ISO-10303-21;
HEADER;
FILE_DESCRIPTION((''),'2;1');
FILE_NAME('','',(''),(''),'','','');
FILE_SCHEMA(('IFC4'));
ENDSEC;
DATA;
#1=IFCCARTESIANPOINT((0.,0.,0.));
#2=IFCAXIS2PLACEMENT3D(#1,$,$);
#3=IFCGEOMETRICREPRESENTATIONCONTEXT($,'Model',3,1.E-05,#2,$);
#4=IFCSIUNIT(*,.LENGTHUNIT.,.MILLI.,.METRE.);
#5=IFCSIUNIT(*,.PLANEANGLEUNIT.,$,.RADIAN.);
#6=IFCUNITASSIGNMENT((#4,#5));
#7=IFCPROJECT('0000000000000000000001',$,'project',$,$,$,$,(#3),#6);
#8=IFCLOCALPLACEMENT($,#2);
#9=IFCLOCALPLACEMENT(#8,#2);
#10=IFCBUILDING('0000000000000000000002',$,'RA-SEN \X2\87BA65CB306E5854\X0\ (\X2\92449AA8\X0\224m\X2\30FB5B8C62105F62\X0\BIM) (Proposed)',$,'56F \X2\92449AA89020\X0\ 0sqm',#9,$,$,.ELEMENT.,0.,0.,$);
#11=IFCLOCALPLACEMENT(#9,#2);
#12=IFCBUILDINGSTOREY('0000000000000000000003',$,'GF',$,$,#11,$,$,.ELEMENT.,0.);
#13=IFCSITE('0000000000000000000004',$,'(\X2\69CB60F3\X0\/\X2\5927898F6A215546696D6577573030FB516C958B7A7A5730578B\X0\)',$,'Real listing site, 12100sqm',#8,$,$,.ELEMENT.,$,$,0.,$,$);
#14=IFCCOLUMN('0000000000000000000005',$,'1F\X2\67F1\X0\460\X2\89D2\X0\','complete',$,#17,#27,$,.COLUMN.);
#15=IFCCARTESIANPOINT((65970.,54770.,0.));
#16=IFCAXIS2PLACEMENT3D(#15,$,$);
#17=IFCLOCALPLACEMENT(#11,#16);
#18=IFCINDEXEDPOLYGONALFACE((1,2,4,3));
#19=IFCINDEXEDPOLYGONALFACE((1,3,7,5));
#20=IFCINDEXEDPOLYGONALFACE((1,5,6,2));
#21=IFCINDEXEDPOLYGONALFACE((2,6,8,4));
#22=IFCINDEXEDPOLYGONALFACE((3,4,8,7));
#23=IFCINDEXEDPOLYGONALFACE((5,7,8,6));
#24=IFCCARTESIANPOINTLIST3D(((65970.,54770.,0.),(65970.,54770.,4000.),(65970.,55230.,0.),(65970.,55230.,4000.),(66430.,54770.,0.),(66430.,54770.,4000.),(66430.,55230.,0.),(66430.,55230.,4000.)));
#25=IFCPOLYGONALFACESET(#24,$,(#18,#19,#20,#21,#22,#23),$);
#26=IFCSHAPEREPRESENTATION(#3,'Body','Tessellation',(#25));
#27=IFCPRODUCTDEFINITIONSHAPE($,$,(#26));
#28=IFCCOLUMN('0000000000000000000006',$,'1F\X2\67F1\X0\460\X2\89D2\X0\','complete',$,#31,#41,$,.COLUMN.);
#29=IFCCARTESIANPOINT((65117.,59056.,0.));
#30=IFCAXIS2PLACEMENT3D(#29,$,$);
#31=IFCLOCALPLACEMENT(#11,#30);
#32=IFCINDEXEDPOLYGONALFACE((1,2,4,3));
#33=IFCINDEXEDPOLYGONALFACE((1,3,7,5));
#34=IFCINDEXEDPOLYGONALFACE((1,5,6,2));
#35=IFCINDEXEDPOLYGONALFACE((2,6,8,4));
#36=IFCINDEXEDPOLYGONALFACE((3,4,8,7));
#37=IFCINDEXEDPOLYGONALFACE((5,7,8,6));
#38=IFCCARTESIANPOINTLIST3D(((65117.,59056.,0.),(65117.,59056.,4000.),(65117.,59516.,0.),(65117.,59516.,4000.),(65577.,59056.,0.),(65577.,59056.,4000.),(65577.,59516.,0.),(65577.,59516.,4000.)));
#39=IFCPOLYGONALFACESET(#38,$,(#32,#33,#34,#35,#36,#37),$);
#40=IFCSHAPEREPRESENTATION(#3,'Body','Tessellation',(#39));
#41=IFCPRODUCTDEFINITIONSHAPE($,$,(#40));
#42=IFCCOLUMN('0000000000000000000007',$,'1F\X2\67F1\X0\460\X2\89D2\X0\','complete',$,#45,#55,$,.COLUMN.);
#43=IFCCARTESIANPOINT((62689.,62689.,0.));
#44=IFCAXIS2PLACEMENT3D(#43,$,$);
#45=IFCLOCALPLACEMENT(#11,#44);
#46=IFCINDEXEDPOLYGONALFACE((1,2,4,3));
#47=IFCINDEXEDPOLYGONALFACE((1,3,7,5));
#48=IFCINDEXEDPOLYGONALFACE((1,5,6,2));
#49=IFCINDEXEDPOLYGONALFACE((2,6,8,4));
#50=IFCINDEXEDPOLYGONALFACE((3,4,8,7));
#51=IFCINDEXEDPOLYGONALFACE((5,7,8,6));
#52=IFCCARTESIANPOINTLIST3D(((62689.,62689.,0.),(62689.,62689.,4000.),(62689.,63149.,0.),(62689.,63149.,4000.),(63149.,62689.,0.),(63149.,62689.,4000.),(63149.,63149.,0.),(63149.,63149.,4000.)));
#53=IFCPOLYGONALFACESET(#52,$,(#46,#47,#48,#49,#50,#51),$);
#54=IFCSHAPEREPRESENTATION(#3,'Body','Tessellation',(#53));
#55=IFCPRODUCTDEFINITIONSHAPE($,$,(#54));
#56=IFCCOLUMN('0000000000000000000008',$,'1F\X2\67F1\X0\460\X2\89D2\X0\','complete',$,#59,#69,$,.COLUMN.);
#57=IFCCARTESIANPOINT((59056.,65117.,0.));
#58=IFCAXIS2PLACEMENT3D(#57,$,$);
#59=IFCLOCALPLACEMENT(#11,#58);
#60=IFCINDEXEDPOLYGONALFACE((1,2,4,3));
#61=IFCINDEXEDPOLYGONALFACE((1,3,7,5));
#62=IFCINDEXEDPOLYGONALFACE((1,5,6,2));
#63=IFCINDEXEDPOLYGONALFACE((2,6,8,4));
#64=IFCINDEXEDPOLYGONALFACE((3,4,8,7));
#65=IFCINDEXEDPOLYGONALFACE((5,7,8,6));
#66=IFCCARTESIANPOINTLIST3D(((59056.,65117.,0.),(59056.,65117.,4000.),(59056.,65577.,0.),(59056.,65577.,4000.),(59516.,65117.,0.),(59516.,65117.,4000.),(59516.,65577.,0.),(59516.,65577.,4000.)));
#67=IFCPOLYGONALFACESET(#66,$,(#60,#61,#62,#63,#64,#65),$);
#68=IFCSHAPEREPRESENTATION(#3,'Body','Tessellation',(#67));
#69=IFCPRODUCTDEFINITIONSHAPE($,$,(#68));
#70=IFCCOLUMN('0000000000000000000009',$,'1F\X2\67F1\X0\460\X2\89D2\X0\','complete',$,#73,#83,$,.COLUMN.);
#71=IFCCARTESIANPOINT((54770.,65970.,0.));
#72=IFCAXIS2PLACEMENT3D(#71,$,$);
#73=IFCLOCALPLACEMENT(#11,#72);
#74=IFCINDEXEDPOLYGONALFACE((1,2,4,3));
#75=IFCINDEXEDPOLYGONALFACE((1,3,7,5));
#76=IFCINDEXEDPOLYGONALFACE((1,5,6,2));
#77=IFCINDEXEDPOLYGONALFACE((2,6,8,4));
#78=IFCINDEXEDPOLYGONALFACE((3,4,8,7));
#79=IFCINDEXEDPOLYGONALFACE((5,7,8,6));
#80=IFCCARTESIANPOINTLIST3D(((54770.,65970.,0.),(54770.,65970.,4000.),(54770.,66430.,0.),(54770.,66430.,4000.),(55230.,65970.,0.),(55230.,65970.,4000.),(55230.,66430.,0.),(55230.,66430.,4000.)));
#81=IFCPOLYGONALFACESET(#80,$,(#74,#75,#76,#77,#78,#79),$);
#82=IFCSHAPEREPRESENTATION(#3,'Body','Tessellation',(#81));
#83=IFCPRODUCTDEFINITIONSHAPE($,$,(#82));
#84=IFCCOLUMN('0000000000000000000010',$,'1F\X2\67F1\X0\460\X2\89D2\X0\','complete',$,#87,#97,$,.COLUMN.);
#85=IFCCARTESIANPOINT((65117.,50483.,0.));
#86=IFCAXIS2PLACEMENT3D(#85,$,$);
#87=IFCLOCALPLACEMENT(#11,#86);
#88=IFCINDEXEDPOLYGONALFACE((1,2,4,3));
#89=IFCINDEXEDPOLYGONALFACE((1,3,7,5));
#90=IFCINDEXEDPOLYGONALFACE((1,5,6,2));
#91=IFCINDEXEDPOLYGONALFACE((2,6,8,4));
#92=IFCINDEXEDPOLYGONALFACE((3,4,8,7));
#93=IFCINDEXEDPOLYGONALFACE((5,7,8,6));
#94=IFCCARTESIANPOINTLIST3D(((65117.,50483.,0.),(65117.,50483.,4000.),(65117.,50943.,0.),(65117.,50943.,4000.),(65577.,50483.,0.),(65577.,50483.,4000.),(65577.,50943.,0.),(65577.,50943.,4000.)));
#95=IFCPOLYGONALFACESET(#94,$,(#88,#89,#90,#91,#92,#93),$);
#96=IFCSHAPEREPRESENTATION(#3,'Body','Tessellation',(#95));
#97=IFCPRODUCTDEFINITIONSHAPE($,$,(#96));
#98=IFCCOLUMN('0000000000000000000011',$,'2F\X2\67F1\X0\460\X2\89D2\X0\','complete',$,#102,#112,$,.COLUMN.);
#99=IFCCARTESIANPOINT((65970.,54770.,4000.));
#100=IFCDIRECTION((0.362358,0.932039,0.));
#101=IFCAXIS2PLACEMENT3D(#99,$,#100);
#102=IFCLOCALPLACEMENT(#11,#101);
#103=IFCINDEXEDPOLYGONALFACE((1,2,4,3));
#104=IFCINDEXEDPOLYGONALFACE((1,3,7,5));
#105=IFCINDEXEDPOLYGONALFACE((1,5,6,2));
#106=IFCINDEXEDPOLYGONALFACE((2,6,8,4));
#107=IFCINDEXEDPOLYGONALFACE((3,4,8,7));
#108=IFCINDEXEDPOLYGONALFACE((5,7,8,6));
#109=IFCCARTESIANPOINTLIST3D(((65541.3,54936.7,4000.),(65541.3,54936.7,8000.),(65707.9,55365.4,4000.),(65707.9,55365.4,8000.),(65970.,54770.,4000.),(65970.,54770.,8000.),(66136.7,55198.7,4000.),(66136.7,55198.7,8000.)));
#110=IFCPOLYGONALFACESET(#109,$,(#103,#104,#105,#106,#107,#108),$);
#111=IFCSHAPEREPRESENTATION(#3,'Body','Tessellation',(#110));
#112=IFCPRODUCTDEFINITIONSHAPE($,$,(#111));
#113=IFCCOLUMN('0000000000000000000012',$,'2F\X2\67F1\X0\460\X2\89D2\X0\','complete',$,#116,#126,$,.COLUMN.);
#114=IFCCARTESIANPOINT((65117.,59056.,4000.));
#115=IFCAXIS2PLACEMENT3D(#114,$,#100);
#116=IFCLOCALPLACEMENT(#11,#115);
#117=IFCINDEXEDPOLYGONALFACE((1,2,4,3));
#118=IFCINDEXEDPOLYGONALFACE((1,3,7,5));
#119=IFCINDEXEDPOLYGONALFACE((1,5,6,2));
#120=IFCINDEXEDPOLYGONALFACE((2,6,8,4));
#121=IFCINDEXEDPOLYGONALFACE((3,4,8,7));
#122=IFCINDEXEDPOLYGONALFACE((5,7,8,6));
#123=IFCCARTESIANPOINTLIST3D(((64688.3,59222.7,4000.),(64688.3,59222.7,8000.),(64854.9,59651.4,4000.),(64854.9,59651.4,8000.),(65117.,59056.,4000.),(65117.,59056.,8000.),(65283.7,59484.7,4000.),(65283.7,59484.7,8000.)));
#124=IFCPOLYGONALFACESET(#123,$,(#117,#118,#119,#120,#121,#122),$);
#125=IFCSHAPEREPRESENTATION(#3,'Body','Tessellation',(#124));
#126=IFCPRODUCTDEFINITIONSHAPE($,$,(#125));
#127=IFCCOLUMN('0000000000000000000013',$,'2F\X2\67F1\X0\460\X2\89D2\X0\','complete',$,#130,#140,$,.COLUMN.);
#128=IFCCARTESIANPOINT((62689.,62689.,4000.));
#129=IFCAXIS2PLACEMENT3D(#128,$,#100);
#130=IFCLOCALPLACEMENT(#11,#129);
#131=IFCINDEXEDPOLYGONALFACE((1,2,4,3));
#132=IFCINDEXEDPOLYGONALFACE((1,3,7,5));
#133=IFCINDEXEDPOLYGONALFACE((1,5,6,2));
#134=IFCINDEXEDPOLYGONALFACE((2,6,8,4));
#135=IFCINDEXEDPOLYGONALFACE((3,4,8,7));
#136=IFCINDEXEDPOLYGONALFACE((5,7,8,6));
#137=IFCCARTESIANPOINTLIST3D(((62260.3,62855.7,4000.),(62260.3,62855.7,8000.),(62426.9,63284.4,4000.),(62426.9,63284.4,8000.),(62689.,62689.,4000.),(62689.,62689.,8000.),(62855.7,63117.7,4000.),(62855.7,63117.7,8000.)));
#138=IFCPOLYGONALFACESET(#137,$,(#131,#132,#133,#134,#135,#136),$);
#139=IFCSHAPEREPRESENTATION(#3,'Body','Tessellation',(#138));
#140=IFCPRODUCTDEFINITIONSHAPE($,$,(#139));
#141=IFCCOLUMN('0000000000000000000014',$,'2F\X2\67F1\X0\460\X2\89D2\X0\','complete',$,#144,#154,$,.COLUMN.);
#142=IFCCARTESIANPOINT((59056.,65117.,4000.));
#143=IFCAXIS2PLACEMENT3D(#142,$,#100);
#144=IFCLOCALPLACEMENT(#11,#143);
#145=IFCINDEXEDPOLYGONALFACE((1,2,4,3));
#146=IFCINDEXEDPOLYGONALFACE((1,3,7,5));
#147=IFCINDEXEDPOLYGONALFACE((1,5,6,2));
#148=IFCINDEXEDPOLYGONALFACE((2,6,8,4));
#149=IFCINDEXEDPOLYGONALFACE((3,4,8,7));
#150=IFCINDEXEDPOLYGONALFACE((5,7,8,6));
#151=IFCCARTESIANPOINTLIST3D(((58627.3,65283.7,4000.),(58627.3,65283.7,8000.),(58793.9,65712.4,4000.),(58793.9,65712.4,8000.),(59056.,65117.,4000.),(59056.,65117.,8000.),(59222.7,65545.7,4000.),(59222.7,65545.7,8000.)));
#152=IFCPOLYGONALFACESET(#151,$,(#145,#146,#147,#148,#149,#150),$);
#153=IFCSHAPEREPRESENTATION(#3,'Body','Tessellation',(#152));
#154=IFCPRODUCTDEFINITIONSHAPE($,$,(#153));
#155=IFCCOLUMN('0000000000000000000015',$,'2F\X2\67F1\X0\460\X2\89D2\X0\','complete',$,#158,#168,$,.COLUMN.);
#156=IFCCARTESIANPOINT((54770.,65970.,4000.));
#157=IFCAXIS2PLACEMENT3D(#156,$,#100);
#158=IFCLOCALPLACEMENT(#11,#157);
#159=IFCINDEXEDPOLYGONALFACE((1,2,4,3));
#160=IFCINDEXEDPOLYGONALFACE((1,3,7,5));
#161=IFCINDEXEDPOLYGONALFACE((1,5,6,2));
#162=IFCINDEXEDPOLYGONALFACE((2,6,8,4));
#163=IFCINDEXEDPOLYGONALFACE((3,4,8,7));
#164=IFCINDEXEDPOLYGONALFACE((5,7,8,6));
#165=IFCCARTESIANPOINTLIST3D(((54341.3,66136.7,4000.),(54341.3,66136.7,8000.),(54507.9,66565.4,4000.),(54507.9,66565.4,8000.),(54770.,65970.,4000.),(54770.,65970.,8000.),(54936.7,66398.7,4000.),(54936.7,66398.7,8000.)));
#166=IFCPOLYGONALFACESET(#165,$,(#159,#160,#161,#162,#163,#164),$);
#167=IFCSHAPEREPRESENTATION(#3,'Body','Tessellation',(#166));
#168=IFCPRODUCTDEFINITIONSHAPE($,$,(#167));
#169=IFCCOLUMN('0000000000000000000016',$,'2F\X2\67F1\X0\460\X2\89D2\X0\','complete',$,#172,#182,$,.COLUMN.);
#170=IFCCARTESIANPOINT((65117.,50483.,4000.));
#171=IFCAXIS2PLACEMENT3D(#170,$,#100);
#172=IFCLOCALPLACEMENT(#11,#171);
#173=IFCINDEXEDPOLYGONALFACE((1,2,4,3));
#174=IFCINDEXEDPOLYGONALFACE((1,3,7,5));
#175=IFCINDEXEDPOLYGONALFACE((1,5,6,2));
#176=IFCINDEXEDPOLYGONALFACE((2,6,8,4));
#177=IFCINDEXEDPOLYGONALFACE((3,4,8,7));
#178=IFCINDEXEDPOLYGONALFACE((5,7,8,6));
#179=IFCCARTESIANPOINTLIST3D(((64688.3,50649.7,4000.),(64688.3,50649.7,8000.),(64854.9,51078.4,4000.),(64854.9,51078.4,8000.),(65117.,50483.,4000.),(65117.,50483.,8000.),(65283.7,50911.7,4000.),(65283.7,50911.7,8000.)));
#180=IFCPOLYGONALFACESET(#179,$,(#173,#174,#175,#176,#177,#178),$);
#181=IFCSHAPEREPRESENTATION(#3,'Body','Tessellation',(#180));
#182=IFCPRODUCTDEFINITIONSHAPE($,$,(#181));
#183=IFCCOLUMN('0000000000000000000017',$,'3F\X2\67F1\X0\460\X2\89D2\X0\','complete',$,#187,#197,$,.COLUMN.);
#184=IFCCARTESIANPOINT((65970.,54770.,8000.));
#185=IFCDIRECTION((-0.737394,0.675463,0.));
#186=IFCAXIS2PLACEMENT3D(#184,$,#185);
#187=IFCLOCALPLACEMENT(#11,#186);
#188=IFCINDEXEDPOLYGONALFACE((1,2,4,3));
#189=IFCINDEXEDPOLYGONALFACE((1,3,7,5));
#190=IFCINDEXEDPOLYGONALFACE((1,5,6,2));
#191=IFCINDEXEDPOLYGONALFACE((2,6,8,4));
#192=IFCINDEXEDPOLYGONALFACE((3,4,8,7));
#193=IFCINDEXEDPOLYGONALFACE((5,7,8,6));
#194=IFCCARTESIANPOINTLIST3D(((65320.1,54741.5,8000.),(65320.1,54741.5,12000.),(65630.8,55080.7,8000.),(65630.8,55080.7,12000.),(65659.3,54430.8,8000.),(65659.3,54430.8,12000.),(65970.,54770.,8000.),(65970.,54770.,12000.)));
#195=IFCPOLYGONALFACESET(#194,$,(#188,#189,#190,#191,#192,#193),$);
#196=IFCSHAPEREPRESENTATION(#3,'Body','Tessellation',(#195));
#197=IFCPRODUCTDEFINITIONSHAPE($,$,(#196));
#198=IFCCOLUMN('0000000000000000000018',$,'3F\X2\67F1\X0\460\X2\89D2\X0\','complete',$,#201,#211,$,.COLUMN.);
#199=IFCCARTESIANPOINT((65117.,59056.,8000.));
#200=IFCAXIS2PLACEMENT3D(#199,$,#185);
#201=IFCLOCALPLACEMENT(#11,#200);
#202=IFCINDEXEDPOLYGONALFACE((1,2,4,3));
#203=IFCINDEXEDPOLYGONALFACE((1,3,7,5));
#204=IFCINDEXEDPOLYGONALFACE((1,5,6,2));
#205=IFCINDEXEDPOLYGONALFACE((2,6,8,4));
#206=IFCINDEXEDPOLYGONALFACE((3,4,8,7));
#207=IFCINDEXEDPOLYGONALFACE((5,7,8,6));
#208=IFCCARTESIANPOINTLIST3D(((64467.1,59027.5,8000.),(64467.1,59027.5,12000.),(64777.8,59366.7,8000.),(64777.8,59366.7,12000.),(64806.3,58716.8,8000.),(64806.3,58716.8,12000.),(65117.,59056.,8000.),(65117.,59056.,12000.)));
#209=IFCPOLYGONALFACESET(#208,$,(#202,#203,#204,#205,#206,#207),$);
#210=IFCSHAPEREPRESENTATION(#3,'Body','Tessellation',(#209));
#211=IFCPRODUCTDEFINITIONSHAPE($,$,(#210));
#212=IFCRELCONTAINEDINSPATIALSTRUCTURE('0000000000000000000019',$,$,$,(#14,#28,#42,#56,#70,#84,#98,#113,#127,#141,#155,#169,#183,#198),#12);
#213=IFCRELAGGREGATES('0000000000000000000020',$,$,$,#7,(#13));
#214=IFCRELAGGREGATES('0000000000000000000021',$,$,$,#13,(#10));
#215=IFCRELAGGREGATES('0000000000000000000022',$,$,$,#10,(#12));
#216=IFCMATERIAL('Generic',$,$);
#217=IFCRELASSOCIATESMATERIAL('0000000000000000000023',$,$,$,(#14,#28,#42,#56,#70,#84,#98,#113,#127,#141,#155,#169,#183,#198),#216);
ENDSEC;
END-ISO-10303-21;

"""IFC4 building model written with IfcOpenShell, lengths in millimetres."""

from ifc_helpers import new_model, si_unit, frame, frame_2d, origin, place, context, project, spatial, rectangle, extrude, material, element, save


model = new_model("IFC4")

# Units and contexts
model_context = context("Model", 3, precision=1e-05, world=origin())
ifc_project = project(units=[si_unit("LENGTHUNIT", "METRE", prefix="MILLI"), si_unit("PLANEANGLEUNIT", "RADIAN")], contexts=[model_context])

# Site, building, storey
site_placement = place(None, origin())
site = spatial("IfcSite", under=ifc_project, at=site_placement, Name="(構想/大規模商業敷地・公開空地型)", ObjectType="Real listing site, 12100sqm", CompositionType="ELEMENT", RefElevation=0.0)
building_placement = place(site_placement, origin())
building = spatial("IfcBuilding", under=site, at=building_placement, Name="RA-SEN 螺旋の塔 (鉄骨224m・完成形BIM) (Proposed)", ObjectType="56F 鉄骨造 0sqm", CompositionType="ELEMENT", ElevationOfRefHeight=0.0, ElevationOfTerrain=0.0)
storey_placement = place(building_placement, origin())
storey = spatial("IfcBuildingStorey", under=building, at=storey_placement, Name="GF", CompositionType="ELEMENT", Elevation=0.0)

# Columns
ifc_material = material(Name="Generic")
column_1_placement = place(storey_placement, frame((65970.0, 54770.0, 0.0)))
element("IfcColumn", 1, at=column_1_placement, inside=storey, material=ifc_material, Name="1F柱460角", Description="complete", PredefinedType="COLUMN", context=model_context, shape_type="SweptSolid", body=[
    extrude(rectangle(XDim=460.0, YDim=460.0, at=frame_2d((230.0, 230.0))), frame((65970.0, 54770.0, 0.0)), (0.0, 0.0, 1.0), 4000.0),
])
column_2_placement = place(storey_placement, frame((65117.0, 59056.0, 0.0)))
element("IfcColumn", 2, at=column_2_placement, inside=storey, material=ifc_material, Name="1F柱460角", Description="complete", PredefinedType="COLUMN", context=model_context, shape_type="SweptSolid", body=[
    extrude(rectangle(XDim=460.0, YDim=460.0, at=frame_2d((230.0, 230.0))), frame((65117.0, 59056.0, 0.0)), (0.0, 0.0, 1.0), 4000.0),
])
column_3_placement = place(storey_placement, frame((62689.0, 62689.0, 0.0)))
element("IfcColumn", 3, at=column_3_placement, inside=storey, material=ifc_material, Name="1F柱460角", Description="complete", PredefinedType="COLUMN", context=model_context, shape_type="SweptSolid", body=[
    extrude(rectangle(XDim=460.0, YDim=460.0, at=frame_2d((230.0, 230.0))), frame((62689.0, 62689.0, 0.0)), (0.0, 0.0, 1.0), 4000.0),
])
column_4_placement = place(storey_placement, frame((59056.0, 65117.0, 0.0)))
element("IfcColumn", 4, at=column_4_placement, inside=storey, material=ifc_material, Name="1F柱460角", Description="complete", PredefinedType="COLUMN", context=model_context, shape_type="SweptSolid", body=[
    extrude(rectangle(XDim=460.0, YDim=460.0, at=frame_2d((230.0, 230.0))), frame((59056.0, 65117.0, 0.0)), (0.0, 0.0, 1.0), 4000.0),
])
column_5_placement = place(storey_placement, frame((54770.0, 65970.0, 0.0)))
element("IfcColumn", 5, at=column_5_placement, inside=storey, material=ifc_material, Name="1F柱460角", Description="complete", PredefinedType="COLUMN", context=model_context, shape_type="SweptSolid", body=[
    extrude(rectangle(XDim=460.0, YDim=460.0, at=frame_2d((230.0, 230.0))), frame((54770.0, 65970.0, 0.0)), (0.0, 0.0, 1.0), 4000.0),
])
column_6_placement = place(storey_placement, frame((65117.0, 50483.0, 0.0)))
element("IfcColumn", 6, at=column_6_placement, inside=storey, material=ifc_material, Name="1F柱460角", Description="complete", PredefinedType="COLUMN", context=model_context, shape_type="SweptSolid", body=[
    extrude(rectangle(XDim=460.0, YDim=460.0, at=frame_2d((230.0, 230.0))), frame((65117.0, 50483.0, 0.0)), (0.0, 0.0, 1.0), 4000.0),
])
column_7_placement = place(storey_placement, frame((65970.0, 54770.0, 4000.0), x_axis=(0.362358, 0.932039, 0.0)))
element("IfcColumn", 7, at=column_7_placement, inside=storey, material=ifc_material, Name="2F柱460角", Description="complete", PredefinedType="COLUMN", context=model_context, shape_type="SweptSolid", body=[
    extrude(rectangle(XDim=460.0, YDim=460.0, at=frame_2d((230.0, 230.0))), frame((65970.0, 54770.0, 4000.0), x_axis=(0.362358, 0.932039, 0.0)), (0.0, 0.0, 1.0), 4000.0),
])
column_8_placement = place(storey_placement, frame((65117.0, 59056.0, 4000.0), x_axis=(0.362358, 0.932039, 0.0)))
element("IfcColumn", 8, at=column_8_placement, inside=storey, material=ifc_material, Name="2F柱460角", Description="complete", PredefinedType="COLUMN", context=model_context, shape_type="SweptSolid", body=[
    extrude(rectangle(XDim=460.0, YDim=460.0, at=frame_2d((230.0, 230.0))), frame((65117.0, 59056.0, 4000.0), x_axis=(0.362358, 0.932039, 0.0)), (0.0, 0.0, 1.0), 4000.0),
])
column_9_placement = place(storey_placement, frame((62689.0, 62689.0, 4000.0), x_axis=(0.362358, 0.932039, 0.0)))
element("IfcColumn", 9, at=column_9_placement, inside=storey, material=ifc_material, Name="2F柱460角", Description="complete", PredefinedType="COLUMN", context=model_context, shape_type="SweptSolid", body=[
    extrude(rectangle(XDim=460.0, YDim=460.0, at=frame_2d((230.0, 230.0))), frame((62689.0, 62689.0, 4000.0), x_axis=(0.362358, 0.932039, 0.0)), (0.0, 0.0, 1.0), 4000.0),
])
column_10_placement = place(storey_placement, frame((59056.0, 65117.0, 4000.0), x_axis=(0.362358, 0.932039, 0.0)))
element("IfcColumn", 10, at=column_10_placement, inside=storey, material=ifc_material, Name="2F柱460角", Description="complete", PredefinedType="COLUMN", context=model_context, shape_type="SweptSolid", body=[
    extrude(rectangle(XDim=460.0, YDim=460.0, at=frame_2d((230.0, 230.0))), frame((59056.0, 65117.0, 4000.0), x_axis=(0.362358, 0.932039, 0.0)), (0.0, 0.0, 1.0), 4000.0),
])
column_11_placement = place(storey_placement, frame((54770.0, 65970.0, 4000.0), x_axis=(0.362358, 0.932039, 0.0)))
element("IfcColumn", 11, at=column_11_placement, inside=storey, material=ifc_material, Name="2F柱460角", Description="complete", PredefinedType="COLUMN", context=model_context, shape_type="SweptSolid", body=[
    extrude(rectangle(XDim=460.0, YDim=460.0, at=frame_2d((230.0, 230.0))), frame((54770.0, 65970.0, 4000.0), x_axis=(0.362358, 0.932039, 0.0)), (0.0, 0.0, 1.0), 4000.0),
])
column_12_placement = place(storey_placement, frame((65117.0, 50483.0, 4000.0), x_axis=(0.362358, 0.932039, 0.0)))
element("IfcColumn", 12, at=column_12_placement, inside=storey, material=ifc_material, Name="2F柱460角", Description="complete", PredefinedType="COLUMN", context=model_context, shape_type="SweptSolid", body=[
    extrude(rectangle(XDim=460.0, YDim=460.0, at=frame_2d((230.0, 230.0))), frame((65117.0, 50483.0, 4000.0), x_axis=(0.362358, 0.932039, 0.0)), (0.0, 0.0, 1.0), 4000.0),
])
column_13_placement = place(storey_placement, frame((65970.0, 54770.0, 8000.0), x_axis=(-0.737394, 0.675463, 0.0)))
element("IfcColumn", 13, at=column_13_placement, inside=storey, material=ifc_material, Name="3F柱460角", Description="complete", PredefinedType="COLUMN", context=model_context, shape_type="SweptSolid", body=[
    extrude(rectangle(XDim=460.0, YDim=460.0, at=frame_2d((230.0, 230.0))), frame((65970.0, 54770.0, 8000.0), x_axis=(-0.737394, 0.675463, 0.0)), (0.0, 0.0, 1.0), 4000.0),
])
column_14_placement = place(storey_placement, frame((65117.0, 59056.0, 8000.0), x_axis=(-0.737394, 0.675463, 0.0)))
element("IfcColumn", 14, at=column_14_placement, inside=storey, material=ifc_material, Name="3F柱460角", Description="complete", PredefinedType="COLUMN", context=model_context, shape_type="SweptSolid", body=[
    extrude(rectangle(XDim=460.0, YDim=460.0, at=frame_2d((230.0, 230.0))), frame((65117.0, 59056.0, 8000.0), x_axis=(-0.737394, 0.675463, 0.0)), (0.0, 0.0, 1.0), 4000.0),
])

save(model, "model.ifc")
